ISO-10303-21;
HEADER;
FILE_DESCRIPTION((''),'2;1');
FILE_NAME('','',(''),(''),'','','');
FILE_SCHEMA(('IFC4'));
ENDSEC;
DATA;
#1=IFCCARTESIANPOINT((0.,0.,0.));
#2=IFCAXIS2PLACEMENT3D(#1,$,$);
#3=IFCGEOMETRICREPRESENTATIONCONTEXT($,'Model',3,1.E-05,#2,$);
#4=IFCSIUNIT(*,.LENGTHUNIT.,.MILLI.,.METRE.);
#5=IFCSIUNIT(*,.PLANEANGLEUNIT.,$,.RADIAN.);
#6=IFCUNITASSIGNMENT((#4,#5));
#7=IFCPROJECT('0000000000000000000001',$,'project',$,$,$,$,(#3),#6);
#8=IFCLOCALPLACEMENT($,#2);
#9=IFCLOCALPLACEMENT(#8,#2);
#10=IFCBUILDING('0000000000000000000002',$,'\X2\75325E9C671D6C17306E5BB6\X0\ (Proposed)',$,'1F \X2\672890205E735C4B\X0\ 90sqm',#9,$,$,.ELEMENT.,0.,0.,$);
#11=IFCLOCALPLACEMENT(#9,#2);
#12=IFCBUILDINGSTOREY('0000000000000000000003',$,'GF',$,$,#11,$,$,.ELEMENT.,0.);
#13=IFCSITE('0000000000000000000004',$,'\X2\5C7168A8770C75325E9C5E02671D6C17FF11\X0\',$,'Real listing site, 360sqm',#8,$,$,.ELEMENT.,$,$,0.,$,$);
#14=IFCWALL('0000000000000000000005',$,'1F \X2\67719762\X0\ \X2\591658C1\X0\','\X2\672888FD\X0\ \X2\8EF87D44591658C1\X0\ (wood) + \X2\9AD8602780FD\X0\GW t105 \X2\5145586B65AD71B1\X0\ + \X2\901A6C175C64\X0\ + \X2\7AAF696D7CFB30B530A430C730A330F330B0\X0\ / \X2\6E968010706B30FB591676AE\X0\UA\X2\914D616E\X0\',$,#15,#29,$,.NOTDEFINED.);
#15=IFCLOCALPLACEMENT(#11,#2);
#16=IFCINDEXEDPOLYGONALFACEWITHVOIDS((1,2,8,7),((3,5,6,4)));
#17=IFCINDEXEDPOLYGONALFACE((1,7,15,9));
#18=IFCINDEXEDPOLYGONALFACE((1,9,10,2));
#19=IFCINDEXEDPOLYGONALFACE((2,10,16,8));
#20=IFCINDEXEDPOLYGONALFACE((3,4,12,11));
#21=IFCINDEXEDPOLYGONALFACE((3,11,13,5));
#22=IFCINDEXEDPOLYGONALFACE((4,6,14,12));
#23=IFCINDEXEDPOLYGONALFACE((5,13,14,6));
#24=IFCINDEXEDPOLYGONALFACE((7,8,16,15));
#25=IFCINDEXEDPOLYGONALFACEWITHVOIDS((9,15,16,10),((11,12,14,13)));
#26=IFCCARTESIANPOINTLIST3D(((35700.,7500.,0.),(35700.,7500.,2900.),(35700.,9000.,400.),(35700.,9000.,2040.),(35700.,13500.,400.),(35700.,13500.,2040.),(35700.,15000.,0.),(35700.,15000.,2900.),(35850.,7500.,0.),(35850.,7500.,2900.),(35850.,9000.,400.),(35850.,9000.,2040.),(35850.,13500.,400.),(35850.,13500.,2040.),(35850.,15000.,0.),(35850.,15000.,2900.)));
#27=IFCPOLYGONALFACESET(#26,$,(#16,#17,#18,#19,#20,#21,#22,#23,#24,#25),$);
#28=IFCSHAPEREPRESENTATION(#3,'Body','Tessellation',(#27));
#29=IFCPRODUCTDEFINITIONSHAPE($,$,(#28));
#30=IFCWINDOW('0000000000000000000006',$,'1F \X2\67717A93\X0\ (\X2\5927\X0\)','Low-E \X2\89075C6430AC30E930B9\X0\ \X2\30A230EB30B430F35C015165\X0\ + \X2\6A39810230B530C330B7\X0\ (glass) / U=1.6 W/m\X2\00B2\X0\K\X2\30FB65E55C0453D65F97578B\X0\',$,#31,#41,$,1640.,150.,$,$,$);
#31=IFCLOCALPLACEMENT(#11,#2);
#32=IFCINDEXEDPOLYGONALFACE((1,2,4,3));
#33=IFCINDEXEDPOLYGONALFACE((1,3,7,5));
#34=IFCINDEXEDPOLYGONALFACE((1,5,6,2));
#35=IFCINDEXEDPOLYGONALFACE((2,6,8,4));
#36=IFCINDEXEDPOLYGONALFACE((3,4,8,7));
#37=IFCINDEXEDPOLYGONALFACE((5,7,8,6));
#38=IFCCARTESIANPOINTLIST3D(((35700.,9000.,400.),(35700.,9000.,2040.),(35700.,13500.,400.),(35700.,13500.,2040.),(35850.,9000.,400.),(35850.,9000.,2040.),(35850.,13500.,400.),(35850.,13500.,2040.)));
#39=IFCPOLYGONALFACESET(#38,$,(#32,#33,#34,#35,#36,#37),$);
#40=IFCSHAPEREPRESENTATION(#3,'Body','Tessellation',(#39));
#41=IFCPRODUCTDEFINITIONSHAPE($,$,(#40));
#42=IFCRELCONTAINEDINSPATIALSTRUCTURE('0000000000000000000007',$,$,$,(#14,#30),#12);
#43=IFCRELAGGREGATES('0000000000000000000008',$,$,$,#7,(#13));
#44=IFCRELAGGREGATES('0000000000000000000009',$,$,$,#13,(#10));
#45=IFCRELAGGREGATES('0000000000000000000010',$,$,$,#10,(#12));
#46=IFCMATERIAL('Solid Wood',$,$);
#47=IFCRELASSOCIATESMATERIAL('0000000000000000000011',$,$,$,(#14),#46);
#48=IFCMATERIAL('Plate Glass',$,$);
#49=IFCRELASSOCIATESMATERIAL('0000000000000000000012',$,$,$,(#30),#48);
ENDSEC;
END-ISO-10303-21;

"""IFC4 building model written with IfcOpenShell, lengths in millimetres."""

from ifc_helpers import new_model, si_unit, frame, frame_2d, origin, place, context, project, spatial, rectangle, extrude, material, element, fill, save


model = new_model("IFC4")

# Units and contexts
model_context = context("Model", 3, precision=1e-05, world=origin())
ifc_project = project(units=[si_unit("LENGTHUNIT", "METRE", prefix="MILLI"), si_unit("PLANEANGLEUNIT", "RADIAN")], contexts=[model_context])

# Site, building, storey
site_placement = place(None, origin())
site = spatial("IfcSite", under=ifc_project, at=site_placement, Name="山梨県甲府市朝気１", ObjectType="Real listing site, 360sqm", CompositionType="ELEMENT", RefElevation=0.0)
building_placement = place(site_placement, origin())
building = spatial("IfcBuilding", under=site, at=building_placement, Name="甲府朝気の家 (Proposed)", ObjectType="1F 木造平屋 90sqm", CompositionType="ELEMENT", ElevationOfRefHeight=0.0, ElevationOfTerrain=0.0)
storey_placement = place(building_placement, origin())
storey = spatial("IfcBuildingStorey", under=building, at=storey_placement, Name="GF", CompositionType="ELEMENT", Elevation=0.0)

# Wall, opening, window
ifc_material_1 = material(Name="Solid Wood")
wall_1_placement = place(storey_placement, frame((17850.0, 3750.0, 0.0)))
wall_1 = element("IfcWall", 1, at=wall_1_placement, inside=storey, material=ifc_material_1, Name="1F 東面 外壁", Description="木製 軸組外壁 (wood) + 高性能GW t105 充填断熱 + 通気層 + 窯業系サイディング / 準耐火・外皮UA配慮", PredefinedType="NOTDEFINED", context=model_context, shape_type="SweptSolid", body=[
    extrude(rectangle(XDim=150.0, YDim=7500.0, at=frame_2d((75.0, 3750.0))), frame((17850.0, 3750.0, 0.0)), (0.0, 0.0, 1.0), 2900.0),
])
opening_1_placement = place(storey_placement, frame((17850.0, 4500.0, 200.0)))
opening_1 = element("IfcOpeningElement", 2, at=opening_1_placement, cuts=wall_1, PredefinedType="NOTDEFINED", context=model_context, shape_type="SweptSolid", body=[
    extrude(rectangle(XDim=150.0, YDim=4500.0, at=frame_2d((75.0, 2250.0))), frame((17850.0, 4500.0, 200.0)), (0.0, 0.0, 1.0), 1640.0),
])
ifc_material_2 = material(Name="Plate Glass")
window_1_placement = place(storey_placement, frame((17850.0, 4500.0, 200.0)))
window_1 = element("IfcWindow", 3, at=window_1_placement, inside=storey, material=ifc_material_2, Name="1F 東窓 (大)", Description="Low-E 複層ガラス アルゴン封入 + 樹脂サッシ (glass) / U=1.6 W/m²K・日射取得型", OverallHeight=1640.0, OverallWidth=150.0, context=model_context, shape_type="SweptSolid", body=[
    extrude(rectangle(XDim=150.0, YDim=4500.0, at=frame_2d((75.0, 2250.0))), frame((17850.0, 4500.0, 200.0)), (0.0, 0.0, 1.0), 1640.0),
])
fill(opening_1, window_1)

save(model, "model.ifc")
